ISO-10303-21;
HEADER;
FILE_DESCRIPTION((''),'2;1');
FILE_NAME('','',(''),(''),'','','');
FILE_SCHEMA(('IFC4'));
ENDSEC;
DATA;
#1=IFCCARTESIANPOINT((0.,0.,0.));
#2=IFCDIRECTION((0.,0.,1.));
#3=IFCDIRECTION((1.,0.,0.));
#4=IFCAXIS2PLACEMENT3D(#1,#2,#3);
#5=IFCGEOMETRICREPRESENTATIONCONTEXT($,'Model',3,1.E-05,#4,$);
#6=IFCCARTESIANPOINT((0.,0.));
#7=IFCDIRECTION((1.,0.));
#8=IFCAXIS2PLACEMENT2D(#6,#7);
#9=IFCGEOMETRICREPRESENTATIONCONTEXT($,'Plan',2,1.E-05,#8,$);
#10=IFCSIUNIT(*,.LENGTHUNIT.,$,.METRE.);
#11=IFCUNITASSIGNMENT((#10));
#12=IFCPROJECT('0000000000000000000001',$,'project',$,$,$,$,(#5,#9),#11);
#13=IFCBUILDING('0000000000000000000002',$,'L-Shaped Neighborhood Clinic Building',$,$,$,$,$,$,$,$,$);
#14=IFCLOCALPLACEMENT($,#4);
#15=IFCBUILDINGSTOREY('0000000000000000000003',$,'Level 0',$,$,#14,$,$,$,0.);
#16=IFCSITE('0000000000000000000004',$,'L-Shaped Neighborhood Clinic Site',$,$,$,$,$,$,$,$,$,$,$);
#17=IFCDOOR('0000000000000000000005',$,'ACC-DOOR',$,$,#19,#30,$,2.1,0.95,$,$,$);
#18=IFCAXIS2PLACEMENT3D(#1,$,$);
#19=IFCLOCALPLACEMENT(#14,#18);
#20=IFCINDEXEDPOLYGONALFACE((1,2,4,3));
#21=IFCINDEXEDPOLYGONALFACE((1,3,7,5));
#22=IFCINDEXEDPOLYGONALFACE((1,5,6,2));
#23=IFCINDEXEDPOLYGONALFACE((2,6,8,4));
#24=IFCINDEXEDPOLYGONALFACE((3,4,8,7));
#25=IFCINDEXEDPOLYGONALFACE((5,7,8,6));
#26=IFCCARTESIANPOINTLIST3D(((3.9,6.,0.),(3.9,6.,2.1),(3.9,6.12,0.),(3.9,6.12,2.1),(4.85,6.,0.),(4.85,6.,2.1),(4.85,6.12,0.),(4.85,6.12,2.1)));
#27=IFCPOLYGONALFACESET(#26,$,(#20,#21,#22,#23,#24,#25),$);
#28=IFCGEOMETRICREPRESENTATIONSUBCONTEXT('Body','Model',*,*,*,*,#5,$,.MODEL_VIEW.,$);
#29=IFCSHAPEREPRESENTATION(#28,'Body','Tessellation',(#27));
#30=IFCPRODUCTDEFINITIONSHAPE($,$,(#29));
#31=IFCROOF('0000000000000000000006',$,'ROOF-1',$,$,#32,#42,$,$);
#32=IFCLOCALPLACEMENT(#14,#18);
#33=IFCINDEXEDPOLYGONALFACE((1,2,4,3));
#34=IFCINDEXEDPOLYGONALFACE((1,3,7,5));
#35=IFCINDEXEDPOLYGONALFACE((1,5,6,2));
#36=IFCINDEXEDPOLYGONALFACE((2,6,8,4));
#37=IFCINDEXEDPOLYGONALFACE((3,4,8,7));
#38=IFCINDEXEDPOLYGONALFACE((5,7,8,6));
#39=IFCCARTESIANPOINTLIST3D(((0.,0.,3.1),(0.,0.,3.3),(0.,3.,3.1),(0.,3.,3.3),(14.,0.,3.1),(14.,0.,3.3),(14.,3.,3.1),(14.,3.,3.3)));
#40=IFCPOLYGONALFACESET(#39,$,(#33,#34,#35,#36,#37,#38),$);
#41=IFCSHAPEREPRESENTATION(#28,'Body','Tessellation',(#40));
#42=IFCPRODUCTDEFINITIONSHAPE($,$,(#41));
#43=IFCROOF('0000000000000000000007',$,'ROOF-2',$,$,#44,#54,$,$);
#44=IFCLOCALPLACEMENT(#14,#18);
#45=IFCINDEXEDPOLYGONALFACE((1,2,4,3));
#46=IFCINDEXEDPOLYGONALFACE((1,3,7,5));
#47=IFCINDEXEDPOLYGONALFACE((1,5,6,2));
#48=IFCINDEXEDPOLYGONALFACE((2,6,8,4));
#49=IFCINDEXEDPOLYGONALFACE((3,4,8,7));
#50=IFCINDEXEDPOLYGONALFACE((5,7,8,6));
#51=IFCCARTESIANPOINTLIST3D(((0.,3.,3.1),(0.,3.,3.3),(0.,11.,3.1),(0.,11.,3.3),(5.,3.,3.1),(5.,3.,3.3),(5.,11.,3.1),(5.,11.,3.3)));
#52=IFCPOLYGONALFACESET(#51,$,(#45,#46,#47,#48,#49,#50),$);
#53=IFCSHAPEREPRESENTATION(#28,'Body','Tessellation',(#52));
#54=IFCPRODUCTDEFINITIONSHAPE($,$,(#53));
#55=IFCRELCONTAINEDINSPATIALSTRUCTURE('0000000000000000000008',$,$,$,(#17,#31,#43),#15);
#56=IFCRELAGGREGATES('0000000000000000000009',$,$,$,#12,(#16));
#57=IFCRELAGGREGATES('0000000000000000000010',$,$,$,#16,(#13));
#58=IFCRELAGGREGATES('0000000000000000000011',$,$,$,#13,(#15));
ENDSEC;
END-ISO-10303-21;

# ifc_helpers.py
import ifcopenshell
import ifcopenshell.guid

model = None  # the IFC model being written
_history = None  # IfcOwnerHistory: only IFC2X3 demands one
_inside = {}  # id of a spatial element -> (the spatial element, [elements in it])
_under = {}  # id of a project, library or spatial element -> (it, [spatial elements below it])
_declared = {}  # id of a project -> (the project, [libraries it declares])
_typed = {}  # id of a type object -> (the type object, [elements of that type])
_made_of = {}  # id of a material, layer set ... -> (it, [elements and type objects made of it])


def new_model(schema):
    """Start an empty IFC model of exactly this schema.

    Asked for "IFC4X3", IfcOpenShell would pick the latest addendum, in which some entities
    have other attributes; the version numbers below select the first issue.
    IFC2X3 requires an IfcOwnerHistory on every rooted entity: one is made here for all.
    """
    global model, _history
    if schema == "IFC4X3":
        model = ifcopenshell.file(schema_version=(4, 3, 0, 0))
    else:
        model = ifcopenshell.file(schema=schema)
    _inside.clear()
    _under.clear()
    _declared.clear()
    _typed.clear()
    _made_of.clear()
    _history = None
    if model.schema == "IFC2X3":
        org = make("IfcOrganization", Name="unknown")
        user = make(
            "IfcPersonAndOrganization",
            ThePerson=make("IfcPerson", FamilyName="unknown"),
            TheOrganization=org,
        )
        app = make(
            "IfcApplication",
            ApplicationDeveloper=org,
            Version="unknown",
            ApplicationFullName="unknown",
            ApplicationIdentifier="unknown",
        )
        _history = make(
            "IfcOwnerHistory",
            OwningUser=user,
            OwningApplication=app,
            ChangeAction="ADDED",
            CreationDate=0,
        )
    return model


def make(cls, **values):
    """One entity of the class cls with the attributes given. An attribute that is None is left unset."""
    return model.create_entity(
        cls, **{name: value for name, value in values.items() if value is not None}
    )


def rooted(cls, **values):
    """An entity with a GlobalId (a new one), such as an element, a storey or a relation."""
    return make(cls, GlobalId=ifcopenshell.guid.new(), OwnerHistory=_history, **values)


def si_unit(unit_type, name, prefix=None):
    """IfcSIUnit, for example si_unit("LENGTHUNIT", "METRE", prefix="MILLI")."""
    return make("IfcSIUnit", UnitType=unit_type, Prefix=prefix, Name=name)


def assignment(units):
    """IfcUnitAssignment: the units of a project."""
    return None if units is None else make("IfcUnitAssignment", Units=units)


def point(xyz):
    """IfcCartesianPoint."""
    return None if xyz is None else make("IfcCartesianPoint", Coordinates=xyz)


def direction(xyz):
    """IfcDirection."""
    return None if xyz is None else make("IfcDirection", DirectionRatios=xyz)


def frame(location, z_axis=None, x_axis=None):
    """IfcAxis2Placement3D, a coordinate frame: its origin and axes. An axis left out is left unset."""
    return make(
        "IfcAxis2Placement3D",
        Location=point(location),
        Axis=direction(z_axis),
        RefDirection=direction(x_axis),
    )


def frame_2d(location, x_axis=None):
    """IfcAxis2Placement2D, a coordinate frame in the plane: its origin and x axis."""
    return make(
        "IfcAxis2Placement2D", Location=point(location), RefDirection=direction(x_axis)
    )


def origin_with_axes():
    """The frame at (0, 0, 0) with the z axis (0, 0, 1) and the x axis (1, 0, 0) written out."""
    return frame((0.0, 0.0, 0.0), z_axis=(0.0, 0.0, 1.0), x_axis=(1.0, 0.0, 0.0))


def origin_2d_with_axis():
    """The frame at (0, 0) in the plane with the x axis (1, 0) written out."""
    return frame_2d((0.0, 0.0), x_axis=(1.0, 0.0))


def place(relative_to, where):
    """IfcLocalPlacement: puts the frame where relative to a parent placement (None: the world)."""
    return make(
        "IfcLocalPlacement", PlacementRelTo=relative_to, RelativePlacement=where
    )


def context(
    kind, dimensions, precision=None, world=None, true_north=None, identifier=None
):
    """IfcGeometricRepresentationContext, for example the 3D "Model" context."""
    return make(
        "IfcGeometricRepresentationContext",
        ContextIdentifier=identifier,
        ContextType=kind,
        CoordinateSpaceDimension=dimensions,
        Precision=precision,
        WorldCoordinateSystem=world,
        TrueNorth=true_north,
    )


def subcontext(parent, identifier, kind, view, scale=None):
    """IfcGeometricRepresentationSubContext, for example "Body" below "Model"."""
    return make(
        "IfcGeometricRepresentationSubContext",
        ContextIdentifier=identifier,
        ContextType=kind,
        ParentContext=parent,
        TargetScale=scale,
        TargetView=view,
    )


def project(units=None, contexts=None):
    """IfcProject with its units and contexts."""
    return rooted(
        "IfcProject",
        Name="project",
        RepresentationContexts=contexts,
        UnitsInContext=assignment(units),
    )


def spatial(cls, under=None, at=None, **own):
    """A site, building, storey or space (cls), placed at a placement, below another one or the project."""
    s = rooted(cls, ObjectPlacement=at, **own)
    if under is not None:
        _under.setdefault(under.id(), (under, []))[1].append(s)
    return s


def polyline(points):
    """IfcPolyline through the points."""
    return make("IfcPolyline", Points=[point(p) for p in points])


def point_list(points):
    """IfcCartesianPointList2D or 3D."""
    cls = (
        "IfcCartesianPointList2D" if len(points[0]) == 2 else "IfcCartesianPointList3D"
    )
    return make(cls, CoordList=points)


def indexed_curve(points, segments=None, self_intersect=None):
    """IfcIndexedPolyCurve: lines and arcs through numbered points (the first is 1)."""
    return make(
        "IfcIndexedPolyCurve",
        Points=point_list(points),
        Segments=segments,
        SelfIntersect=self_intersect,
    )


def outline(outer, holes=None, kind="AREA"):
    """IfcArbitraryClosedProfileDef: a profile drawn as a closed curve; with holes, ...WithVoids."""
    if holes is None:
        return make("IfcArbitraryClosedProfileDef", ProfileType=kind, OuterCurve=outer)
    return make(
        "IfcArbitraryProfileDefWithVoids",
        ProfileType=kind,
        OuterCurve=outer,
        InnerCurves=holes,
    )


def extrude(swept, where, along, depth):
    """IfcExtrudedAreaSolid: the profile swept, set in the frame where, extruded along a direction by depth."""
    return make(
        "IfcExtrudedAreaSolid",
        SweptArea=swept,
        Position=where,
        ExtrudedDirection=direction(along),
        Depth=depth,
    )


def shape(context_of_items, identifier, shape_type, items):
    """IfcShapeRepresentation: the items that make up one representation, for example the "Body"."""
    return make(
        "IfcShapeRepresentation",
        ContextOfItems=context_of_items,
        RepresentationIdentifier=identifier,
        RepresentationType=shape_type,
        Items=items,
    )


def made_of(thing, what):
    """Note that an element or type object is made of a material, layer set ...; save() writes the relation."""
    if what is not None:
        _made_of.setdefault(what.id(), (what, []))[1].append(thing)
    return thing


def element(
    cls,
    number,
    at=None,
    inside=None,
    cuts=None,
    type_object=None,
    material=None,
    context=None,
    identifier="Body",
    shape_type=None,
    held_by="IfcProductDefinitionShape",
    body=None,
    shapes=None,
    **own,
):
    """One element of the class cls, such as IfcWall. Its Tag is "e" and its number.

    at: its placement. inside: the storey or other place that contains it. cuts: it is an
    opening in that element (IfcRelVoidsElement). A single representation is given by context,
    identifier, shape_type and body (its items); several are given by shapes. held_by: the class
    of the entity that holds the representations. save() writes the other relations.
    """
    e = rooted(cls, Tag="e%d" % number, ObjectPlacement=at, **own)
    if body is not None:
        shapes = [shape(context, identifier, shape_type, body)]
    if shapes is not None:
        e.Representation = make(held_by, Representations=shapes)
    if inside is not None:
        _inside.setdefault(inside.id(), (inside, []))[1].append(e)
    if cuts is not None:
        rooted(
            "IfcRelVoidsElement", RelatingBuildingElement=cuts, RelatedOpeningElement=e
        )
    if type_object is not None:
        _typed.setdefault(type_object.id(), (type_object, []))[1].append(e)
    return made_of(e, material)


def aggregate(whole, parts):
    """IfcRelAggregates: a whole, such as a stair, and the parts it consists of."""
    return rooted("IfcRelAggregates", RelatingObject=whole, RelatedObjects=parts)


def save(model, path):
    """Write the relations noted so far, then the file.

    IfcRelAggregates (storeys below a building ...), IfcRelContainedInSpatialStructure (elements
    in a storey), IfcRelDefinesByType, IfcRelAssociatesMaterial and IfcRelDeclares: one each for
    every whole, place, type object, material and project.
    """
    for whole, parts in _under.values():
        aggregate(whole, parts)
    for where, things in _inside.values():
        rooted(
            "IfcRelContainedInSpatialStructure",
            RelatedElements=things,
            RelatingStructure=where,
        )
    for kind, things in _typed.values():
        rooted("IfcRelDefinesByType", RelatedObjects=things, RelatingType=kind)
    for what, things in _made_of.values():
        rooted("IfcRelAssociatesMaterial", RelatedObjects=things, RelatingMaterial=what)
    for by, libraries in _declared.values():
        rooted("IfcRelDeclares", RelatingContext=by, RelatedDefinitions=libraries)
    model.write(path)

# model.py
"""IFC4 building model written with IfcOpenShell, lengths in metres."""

from ifc_helpers import new_model, si_unit, frame, origin_with_axes, origin_2d_with_axis, place, context, subcontext, project, spatial, polyline, indexed_curve, outline, extrude, element, save


model = new_model("IFC4")

# Units and contexts
model_context = context("Model", 3, precision=1e-05, world=origin_with_axes())
plan_context = context("Plan", 2, precision=1e-05, world=origin_2d_with_axis())
body_context = subcontext(model_context, "Body", "Model", "MODEL_VIEW")
ifc_project = project(units=[si_unit("LENGTHUNIT", "METRE")], contexts=[model_context, plan_context])

# Site, building, storey
site = spatial("IfcSite", under=ifc_project, Name="L-Shaped Neighborhood Clinic Site")
building = spatial("IfcBuilding", under=site, Name="L-Shaped Neighborhood Clinic Building")
storey_placement = place(None, origin_with_axes())
storey = spatial("IfcBuildingStorey", under=building, at=storey_placement, Name="Level 0", Elevation=0.0)

# Door
door_placement = place(storey_placement, frame((3.9, 6.0, 0.0), z_axis=(0.0, 0.0, 1.0), x_axis=(1.0, 0.0, 0.0)))
element("IfcDoor", 1, at=door_placement, inside=storey, Name="ACC-DOOR", OverallHeight=2.1, OverallWidth=0.95, context=body_context, shape_type="SweptSolid", body=[
    extrude(outline(polyline([(0.0, 0.0), (0.95, 0.0), (0.95, 0.12), (0.0, 0.12), (0.0, 0.0)])), origin_with_axes(), (0.0, 0.0, 1.0), 2.1),
])

# Roofs
roof_1_placement = place(storey_placement, frame((0.0, 0.0, 3.1), z_axis=(0.0, 0.0, 1.0), x_axis=(1.0, 0.0, 0.0)))
element("IfcRoof", 2, at=roof_1_placement, inside=storey, Name="ROOF-1", context=body_context, shape_type="SweptSolid", body=[
    extrude(outline(indexed_curve([(0.0, 0.0), (14.0, 0.0), (14.0, 3.0), (0.0, 3.0)])), None, (0.0, 0.0, 1.0), 0.2),
])
roof_2_placement = place(storey_placement, frame((0.0, 0.0, 3.1), z_axis=(0.0, 0.0, 1.0), x_axis=(1.0, 0.0, 0.0)))
element("IfcRoof", 3, at=roof_2_placement, inside=storey, Name="ROOF-2", context=body_context, shape_type="SweptSolid", body=[
    extrude(outline(indexed_curve([(0.0, 3.0), (5.0, 3.0), (5.0, 11.0), (0.0, 11.0)])), None, (0.0, 0.0, 1.0), 0.2),
])

save(model, "model.ifc")
